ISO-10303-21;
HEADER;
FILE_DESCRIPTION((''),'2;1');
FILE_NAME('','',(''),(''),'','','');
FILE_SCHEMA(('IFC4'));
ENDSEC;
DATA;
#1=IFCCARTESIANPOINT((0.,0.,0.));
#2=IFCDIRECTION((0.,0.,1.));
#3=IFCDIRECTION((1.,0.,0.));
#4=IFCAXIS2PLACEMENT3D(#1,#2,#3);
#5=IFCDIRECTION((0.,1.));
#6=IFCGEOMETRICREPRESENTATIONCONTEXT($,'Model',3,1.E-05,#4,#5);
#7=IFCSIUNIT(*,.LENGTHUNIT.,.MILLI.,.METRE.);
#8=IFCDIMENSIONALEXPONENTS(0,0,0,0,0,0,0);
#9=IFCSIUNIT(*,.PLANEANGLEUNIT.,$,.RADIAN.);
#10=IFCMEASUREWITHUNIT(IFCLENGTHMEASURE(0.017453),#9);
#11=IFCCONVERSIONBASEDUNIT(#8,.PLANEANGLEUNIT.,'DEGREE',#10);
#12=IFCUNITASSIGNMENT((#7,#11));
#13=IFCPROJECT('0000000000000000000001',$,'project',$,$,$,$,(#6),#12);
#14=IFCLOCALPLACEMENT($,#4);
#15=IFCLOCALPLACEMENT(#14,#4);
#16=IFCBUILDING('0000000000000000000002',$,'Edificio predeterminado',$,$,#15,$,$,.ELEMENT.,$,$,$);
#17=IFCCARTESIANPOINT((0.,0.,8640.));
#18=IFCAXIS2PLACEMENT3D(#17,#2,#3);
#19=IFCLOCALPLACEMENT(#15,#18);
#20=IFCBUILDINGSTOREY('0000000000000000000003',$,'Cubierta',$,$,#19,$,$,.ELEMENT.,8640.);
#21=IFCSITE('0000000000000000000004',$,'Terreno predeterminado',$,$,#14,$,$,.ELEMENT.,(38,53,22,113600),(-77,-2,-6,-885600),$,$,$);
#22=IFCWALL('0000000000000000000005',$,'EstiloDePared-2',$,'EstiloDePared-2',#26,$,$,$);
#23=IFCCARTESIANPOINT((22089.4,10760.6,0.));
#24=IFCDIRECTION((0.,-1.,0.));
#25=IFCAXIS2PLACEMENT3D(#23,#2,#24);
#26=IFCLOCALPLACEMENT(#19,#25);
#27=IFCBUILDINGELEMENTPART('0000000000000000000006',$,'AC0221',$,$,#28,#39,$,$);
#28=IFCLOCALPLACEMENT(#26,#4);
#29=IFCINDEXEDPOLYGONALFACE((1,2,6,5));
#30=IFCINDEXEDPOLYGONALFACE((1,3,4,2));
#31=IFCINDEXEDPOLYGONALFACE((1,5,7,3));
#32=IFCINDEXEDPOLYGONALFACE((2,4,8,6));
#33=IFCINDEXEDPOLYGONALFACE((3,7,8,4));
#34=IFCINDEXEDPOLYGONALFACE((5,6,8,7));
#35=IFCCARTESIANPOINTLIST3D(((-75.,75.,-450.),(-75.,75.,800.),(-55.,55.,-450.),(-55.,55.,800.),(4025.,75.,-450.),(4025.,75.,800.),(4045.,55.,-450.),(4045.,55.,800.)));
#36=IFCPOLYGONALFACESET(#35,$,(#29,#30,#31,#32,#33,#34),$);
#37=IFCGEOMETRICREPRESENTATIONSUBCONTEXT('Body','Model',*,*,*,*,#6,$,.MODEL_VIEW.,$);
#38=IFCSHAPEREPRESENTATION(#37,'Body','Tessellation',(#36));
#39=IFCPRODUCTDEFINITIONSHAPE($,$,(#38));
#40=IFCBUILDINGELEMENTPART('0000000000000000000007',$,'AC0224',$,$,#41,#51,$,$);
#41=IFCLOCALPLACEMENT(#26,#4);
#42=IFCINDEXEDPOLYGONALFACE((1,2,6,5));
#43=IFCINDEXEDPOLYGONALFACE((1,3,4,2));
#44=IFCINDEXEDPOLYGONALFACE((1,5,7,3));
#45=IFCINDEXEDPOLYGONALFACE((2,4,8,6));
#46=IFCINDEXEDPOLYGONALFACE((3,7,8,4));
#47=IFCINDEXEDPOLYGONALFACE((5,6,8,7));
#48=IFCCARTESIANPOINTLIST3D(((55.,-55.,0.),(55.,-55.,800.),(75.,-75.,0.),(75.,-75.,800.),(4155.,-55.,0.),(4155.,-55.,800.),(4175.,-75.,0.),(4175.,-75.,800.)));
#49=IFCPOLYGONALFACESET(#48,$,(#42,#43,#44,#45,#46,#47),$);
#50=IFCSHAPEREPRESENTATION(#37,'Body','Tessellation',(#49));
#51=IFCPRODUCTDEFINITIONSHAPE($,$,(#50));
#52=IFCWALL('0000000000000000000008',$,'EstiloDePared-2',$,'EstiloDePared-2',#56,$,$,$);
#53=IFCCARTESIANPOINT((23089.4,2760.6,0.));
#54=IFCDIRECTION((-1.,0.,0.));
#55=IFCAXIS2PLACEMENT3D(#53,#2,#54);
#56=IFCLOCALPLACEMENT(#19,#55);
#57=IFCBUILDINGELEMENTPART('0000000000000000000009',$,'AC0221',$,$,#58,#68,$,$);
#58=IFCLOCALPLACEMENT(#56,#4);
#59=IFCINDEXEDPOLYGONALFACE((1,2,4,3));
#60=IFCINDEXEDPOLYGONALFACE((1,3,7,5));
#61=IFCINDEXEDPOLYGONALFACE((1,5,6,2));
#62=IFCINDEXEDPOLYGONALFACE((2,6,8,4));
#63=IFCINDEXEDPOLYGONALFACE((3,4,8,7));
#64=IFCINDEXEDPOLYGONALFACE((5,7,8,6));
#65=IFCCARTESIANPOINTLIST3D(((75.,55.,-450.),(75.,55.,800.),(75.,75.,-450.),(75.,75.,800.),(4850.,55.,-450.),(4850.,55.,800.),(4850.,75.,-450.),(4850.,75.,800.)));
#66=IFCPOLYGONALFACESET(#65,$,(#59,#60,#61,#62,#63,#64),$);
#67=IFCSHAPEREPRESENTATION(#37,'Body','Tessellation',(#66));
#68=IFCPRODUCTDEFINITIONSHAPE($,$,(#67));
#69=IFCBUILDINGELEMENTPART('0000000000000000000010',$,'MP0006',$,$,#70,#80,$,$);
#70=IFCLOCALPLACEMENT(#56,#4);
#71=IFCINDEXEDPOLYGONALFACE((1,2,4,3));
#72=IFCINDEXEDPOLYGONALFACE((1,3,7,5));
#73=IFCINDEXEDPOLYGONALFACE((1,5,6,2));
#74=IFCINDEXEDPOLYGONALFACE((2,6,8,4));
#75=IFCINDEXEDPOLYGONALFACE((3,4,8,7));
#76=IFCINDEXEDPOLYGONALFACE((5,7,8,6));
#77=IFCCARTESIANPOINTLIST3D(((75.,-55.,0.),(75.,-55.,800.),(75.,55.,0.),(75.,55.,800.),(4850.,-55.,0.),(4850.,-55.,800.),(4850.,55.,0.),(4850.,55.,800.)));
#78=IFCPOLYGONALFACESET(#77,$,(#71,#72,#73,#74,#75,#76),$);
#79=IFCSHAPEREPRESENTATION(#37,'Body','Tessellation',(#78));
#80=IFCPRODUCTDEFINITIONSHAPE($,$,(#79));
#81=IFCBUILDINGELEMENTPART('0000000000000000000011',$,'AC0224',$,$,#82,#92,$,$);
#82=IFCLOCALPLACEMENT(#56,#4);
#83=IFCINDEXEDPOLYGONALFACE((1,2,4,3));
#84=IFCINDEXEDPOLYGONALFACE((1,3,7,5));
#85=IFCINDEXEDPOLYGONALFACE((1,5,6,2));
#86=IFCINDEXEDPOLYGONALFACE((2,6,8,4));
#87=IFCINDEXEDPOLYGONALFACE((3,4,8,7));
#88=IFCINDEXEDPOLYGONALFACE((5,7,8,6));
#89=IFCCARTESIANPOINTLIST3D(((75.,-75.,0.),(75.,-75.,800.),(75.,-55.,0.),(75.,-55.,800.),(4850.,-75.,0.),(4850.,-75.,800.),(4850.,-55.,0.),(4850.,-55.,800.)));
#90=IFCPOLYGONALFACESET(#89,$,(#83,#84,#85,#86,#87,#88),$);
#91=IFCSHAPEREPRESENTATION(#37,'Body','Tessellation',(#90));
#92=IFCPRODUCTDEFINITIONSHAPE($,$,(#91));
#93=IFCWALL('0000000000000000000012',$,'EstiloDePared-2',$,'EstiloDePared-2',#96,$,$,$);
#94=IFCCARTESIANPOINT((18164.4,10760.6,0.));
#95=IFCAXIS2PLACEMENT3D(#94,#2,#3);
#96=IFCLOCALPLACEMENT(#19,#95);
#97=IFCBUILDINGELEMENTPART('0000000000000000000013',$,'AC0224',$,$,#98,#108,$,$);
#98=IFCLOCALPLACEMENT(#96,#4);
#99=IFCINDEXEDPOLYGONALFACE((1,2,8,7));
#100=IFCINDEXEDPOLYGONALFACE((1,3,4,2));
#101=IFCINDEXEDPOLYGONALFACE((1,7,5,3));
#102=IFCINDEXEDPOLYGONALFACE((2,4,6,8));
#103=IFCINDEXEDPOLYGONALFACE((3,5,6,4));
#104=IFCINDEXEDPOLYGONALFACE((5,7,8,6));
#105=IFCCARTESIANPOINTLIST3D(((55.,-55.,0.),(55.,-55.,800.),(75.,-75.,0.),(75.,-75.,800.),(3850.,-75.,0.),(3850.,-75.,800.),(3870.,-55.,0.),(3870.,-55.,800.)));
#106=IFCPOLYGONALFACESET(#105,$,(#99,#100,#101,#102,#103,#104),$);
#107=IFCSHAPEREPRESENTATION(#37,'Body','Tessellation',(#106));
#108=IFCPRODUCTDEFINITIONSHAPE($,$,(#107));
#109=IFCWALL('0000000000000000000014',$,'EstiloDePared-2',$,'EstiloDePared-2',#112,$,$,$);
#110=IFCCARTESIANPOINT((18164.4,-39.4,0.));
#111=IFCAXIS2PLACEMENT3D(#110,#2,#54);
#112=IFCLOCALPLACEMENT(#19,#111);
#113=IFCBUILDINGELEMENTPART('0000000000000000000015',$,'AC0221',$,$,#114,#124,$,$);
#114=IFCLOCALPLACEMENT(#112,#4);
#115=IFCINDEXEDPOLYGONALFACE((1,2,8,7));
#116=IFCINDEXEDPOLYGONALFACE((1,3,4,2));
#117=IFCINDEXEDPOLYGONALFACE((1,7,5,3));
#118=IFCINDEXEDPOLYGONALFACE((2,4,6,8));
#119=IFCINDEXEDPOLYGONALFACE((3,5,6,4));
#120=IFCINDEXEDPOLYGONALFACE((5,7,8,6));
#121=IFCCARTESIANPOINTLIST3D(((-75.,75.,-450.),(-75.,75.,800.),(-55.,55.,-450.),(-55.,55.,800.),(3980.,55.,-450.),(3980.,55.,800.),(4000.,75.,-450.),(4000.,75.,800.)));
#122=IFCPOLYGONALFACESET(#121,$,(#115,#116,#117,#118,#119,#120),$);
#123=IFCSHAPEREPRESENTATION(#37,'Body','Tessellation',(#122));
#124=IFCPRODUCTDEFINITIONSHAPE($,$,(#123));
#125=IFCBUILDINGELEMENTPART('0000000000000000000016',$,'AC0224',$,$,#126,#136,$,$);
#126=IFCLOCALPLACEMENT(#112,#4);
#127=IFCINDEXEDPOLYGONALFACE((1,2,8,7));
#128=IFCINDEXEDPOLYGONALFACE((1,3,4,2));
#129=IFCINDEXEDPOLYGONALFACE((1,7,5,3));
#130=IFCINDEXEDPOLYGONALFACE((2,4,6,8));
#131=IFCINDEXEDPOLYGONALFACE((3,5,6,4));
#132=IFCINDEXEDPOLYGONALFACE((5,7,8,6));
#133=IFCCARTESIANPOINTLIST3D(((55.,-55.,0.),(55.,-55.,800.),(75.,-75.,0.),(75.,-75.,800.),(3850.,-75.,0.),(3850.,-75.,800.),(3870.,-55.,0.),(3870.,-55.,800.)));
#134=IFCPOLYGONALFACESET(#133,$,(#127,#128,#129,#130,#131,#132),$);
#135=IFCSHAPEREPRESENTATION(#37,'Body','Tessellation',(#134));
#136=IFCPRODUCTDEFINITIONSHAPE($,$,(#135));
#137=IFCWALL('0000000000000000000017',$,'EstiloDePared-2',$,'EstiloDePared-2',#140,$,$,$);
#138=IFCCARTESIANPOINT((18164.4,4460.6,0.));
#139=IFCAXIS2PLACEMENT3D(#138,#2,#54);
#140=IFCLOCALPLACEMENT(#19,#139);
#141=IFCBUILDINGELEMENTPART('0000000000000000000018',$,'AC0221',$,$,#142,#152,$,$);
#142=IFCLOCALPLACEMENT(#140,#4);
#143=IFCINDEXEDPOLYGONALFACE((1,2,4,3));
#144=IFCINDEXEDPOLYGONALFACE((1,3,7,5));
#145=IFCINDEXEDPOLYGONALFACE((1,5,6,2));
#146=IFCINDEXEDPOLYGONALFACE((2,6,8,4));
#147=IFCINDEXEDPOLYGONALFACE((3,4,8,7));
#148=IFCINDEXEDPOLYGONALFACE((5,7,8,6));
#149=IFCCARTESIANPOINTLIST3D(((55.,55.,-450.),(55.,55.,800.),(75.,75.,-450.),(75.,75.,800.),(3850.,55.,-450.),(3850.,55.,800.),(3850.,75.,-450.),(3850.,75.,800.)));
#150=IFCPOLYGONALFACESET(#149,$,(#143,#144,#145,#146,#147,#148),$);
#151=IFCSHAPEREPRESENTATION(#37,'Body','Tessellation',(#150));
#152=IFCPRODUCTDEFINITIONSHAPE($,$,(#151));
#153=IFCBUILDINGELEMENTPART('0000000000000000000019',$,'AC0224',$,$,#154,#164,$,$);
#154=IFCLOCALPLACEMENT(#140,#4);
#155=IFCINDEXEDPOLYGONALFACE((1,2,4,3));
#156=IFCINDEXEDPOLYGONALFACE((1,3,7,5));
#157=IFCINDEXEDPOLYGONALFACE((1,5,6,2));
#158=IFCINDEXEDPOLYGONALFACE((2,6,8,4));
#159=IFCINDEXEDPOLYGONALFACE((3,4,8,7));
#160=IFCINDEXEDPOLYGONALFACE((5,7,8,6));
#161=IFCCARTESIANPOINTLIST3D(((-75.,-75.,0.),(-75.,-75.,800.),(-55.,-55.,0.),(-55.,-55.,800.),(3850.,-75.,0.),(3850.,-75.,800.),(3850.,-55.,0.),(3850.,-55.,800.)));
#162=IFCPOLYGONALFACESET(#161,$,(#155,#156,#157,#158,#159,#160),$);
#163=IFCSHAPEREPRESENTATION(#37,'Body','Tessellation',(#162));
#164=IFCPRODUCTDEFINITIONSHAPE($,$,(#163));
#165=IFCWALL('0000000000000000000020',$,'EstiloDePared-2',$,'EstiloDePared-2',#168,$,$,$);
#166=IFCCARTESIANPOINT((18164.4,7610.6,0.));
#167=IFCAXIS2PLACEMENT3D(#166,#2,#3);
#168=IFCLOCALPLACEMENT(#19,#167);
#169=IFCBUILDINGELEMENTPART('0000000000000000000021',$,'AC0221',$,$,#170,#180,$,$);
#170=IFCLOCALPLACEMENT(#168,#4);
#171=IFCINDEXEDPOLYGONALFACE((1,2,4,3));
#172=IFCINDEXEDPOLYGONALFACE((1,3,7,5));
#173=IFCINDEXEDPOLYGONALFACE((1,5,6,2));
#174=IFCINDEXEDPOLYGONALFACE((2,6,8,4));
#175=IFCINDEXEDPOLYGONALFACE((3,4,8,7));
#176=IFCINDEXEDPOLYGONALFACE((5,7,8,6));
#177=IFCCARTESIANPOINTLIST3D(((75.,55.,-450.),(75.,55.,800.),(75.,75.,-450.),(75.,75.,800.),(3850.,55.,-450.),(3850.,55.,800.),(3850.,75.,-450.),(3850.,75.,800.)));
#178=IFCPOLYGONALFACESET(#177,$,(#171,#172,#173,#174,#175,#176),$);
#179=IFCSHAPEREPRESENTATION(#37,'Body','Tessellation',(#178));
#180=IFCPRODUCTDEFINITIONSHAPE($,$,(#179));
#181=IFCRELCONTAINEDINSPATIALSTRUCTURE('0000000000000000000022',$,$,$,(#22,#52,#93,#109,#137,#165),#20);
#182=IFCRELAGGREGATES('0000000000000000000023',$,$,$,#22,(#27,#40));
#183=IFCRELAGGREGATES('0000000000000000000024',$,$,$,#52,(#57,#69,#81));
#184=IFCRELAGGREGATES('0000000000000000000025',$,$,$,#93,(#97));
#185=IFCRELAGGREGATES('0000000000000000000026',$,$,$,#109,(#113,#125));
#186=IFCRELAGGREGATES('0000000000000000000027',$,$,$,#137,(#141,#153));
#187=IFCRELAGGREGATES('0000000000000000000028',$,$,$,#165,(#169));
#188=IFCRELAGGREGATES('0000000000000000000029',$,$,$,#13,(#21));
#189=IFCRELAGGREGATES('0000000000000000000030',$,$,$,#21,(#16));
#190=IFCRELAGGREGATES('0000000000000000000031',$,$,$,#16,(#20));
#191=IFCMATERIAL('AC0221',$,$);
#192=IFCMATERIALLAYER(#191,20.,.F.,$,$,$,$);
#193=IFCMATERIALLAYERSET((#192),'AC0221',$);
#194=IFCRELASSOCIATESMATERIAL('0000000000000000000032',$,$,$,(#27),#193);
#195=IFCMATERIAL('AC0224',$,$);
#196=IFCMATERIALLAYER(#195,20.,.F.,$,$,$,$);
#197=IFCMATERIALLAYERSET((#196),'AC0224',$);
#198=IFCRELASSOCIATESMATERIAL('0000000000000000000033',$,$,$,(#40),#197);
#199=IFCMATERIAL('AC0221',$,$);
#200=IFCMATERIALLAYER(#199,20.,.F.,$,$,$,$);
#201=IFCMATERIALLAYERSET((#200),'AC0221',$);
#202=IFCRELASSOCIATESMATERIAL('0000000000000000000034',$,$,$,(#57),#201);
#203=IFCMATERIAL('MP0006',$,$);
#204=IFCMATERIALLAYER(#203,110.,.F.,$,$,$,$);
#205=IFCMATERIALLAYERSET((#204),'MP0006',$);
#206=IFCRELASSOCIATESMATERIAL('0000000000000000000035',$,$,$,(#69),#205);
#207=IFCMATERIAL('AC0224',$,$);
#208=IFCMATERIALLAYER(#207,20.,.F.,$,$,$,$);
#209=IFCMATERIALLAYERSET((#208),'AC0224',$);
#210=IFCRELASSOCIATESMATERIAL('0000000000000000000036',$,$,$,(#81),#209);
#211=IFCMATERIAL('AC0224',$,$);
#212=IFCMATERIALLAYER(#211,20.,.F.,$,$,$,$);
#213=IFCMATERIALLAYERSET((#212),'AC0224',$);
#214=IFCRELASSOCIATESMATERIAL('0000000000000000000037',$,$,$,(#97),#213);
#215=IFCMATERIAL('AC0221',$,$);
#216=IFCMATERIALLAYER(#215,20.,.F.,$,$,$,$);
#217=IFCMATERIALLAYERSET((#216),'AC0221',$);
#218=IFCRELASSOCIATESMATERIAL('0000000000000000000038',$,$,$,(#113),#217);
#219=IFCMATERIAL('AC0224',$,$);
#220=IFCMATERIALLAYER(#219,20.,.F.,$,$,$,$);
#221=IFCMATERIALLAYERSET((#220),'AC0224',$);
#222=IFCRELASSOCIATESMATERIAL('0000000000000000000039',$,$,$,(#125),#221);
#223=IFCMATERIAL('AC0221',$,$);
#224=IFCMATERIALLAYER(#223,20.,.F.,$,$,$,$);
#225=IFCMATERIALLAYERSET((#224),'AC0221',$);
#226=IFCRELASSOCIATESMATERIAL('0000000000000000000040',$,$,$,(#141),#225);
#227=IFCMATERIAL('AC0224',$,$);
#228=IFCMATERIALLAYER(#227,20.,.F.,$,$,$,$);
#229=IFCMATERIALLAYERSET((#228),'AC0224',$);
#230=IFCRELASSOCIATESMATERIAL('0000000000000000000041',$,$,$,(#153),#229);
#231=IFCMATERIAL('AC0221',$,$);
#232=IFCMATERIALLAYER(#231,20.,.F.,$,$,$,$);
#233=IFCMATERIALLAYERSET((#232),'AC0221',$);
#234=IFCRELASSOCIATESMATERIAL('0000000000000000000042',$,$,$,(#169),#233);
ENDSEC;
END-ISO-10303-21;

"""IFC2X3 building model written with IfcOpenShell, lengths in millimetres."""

from ifc_helpers import new_model, entity, si_unit, converted_unit, direction, frame, origin_with_axes, place, context, subcontext, project, spatial, polyline, outline, extrude, material, layer, layer_set, layer_usage, element, aggregate, save


model = new_model("IFC2X3")

# Units and contexts
model_context = context("Model", 3, precision=1e-05, world=origin_with_axes(), true_north=direction((0.0, 1.0)))
body_context = subcontext(model_context, "Body", "Model", "MODEL_VIEW")
ifc_project = project(units=[si_unit("LENGTHUNIT", "METRE", prefix="MILLI"), converted_unit("PLANEANGLEUNIT", "DEGREE", entity("IfcLengthMeasure", 0.017453), si_unit("PLANEANGLEUNIT", "RADIAN"), dimensions=[0, 0, 0, 0, 0, 0, 0])], contexts=[model_context])

# Site, building, storey
site_placement = place(None, origin_with_axes())
site = spatial("IfcSite", under=ifc_project, at=site_placement, Name="Terreno predeterminado", CompositionType="ELEMENT", RefLatitude=(38, 53, 22, 113600), RefLongitude=(-77, -2, -6, -885600))
building_placement = place(site_placement, origin_with_axes())
building = spatial("IfcBuilding", under=site, at=building_placement, Name="Edificio predeterminado", CompositionType="ELEMENT")
storey_placement = place(building_placement, frame((0.0, 0.0, 8640.0), z_axis=(0.0, 0.0, 1.0), x_axis=(1.0, 0.0, 0.0)))
storey = spatial("IfcBuildingStorey", under=building, at=storey_placement, Name="Cubierta", CompositionType="ELEMENT", Elevation=8640.0)

# Walls, building element parts
wall_1_placement = place(storey_placement, frame((22089.4, 10760.6, 0.0), z_axis=(0.0, 0.0, 1.0), x_axis=(0.0, -1.0, 0.0)))
wall_1 = element("IfcWall", 1, at=wall_1_placement, inside=storey, Name="EstiloDePared-2", ObjectType="EstiloDePared-2")
ifc_material_1 = material(Name="AC0221")
ifc_layer_1 = layer(ifc_material_1, 20.0, ventilated=False)
ifc_layer_set_1 = layer_set([ifc_layer_1], Name="AC0221")
ifc_layer_usage_1 = layer_usage(ifc_layer_set_1, "AXIS2", "NEGATIVE", -75.0)
building_element_part_1_placement = place(wall_1_placement, origin_with_axes())
building_element_part_1 = element("IfcBuildingElementPart", 2, at=building_element_part_1_placement, material=ifc_layer_usage_1, Name="AC0221", context=body_context, shape_type="SweptSolid", body=[
    extrude(outline(polyline([(4025.0, 75.0), (4045.0, 55.0), (-55.0, 55.0), (-75.0, 75.0), (4025.0, 75.0)])), frame((0.0, 0.0, -450.0), z_axis=(0.0, 0.0, 1.0), x_axis=(1.0, 0.0, 0.0)), (0.0, 0.0, 1.0), 1250.0),
])
ifc_material_2 = material(Name="AC0224")
ifc_layer_2 = layer(ifc_material_2, 20.0, ventilated=False)
ifc_layer_set_2 = layer_set([ifc_layer_2], Name="AC0224")
ifc_layer_usage_2 = layer_usage(ifc_layer_set_2, "AXIS2", "NEGATIVE", 55.0)
building_element_part_2_placement = place(wall_1_placement, origin_with_axes())
building_element_part_2 = element("IfcBuildingElementPart", 3, at=building_element_part_2_placement, material=ifc_layer_usage_2, Name="AC0224", context=body_context, shape_type="SweptSolid", body=[
    extrude(outline(polyline([(4155.0, -55.0), (4175.0, -75.0), (75.0, -75.0), (55.0, -55.0), (4155.0, -55.0)])), origin_with_axes(), (0.0, 0.0, 1.0), 800.0),
])
aggregate(wall_1, [building_element_part_1, building_element_part_2])
wall_2_placement = place(storey_placement, frame((23089.4, 2760.6, 0.0), z_axis=(0.0, 0.0, 1.0), x_axis=(-1.0, 0.0, 0.0)))
wall_2 = element("IfcWall", 4, at=wall_2_placement, inside=storey, Name="EstiloDePared-2", ObjectType="EstiloDePared-2")
ifc_material_3 = material(Name="AC0221")
ifc_layer_3 = layer(ifc_material_3, 20.0, ventilated=False)
ifc_layer_set_3 = layer_set([ifc_layer_3], Name="AC0221")
ifc_layer_usage_3 = layer_usage(ifc_layer_set_3, "AXIS2", "NEGATIVE", -75.0)
building_element_part_3_placement = place(wall_2_placement, origin_with_axes())
building_element_part_3 = element("IfcBuildingElementPart", 5, at=building_element_part_3_placement, material=ifc_layer_usage_3, Name="AC0221", context=body_context, shape_type="SweptSolid", body=[
    extrude(outline(polyline([(4850.0, 75.0), (4850.0, 55.0), (75.0, 55.0), (75.0, 75.0), (4850.0, 75.0)])), frame((0.0, 0.0, -450.0), z_axis=(0.0, 0.0, 1.0), x_axis=(1.0, 0.0, 0.0)), (0.0, 0.0, 1.0), 1250.0),
])
ifc_material_4 = material(Name="MP0006")
ifc_layer_4 = layer(ifc_material_4, 110.0, ventilated=False)
ifc_layer_set_4 = layer_set([ifc_layer_4], Name="MP0006")
ifc_layer_usage_4 = layer_usage(ifc_layer_set_4, "AXIS2", "NEGATIVE", -55.0)
building_element_part_4_placement = place(wall_2_placement, origin_with_axes())
building_element_part_4 = element("IfcBuildingElementPart", 6, at=building_element_part_4_placement, material=ifc_layer_usage_4, Name="MP0006", context=body_context, shape_type="SweptSolid", body=[
    extrude(outline(polyline([(4850.0, 55.0), (4850.0, -55.0), (75.0, -55.0), (75.0, 55.0), (4850.0, 55.0)])), origin_with_axes(), (0.0, 0.0, 1.0), 800.0),
])
ifc_material_5 = material(Name="AC0224")
ifc_layer_5 = layer(ifc_material_5, 20.0, ventilated=False)
ifc_layer_set_5 = layer_set([ifc_layer_5], Name="AC0224")
ifc_layer_usage_5 = layer_usage(ifc_layer_set_5, "AXIS2", "NEGATIVE", 55.0)
building_element_part_5_placement = place(wall_2_placement, origin_with_axes())
building_element_part_5 = element("IfcBuildingElementPart", 7, at=building_element_part_5_placement, material=ifc_layer_usage_5, Name="AC0224", context=body_context, shape_type="SweptSolid", body=[
    extrude(outline(polyline([(4850.0, -55.0), (4850.0, -75.0), (75.0, -75.0), (75.0, -55.0), (4850.0, -55.0)])), origin_with_axes(), (0.0, 0.0, 1.0), 800.0),
])
aggregate(wall_2, [building_element_part_3, building_element_part_4, building_element_part_5])

# Wall, building element part
wall_3_placement = place(storey_placement, frame((18164.4, 10760.6, 0.0), z_axis=(0.0, 0.0, 1.0), x_axis=(1.0, 0.0, 0.0)))
wall_3 = element("IfcWall", 8, at=wall_3_placement, inside=storey, Name="EstiloDePared-2", ObjectType="EstiloDePared-2")
ifc_material_6 = material(Name="AC0224")
ifc_layer_6 = layer(ifc_material_6, 20.0, ventilated=False)
ifc_layer_set_6 = layer_set([ifc_layer_6], Name="AC0224")
ifc_layer_usage_6 = layer_usage(ifc_layer_set_6, "AXIS2", "NEGATIVE", 55.0)
building_element_part_6_placement = place(wall_3_placement, origin_with_axes())
building_element_part_6 = element("IfcBuildingElementPart", 9, at=building_element_part_6_placement, material=ifc_layer_usage_6, Name="AC0224", context=body_context, shape_type="SweptSolid", body=[
    extrude(outline(polyline([(3870.0, -55.0), (3850.0, -75.0), (75.0, -75.0), (55.0, -55.0), (3870.0, -55.0)])), origin_with_axes(), (0.0, 0.0, 1.0), 800.0),
])
aggregate(wall_3, [building_element_part_6])

# Walls, building element parts
wall_4_placement = place(storey_placement, frame((18164.4, -39.4, 0.0), z_axis=(0.0, 0.0, 1.0), x_axis=(-1.0, 0.0, 0.0)))
wall_4 = element("IfcWall", 10, at=wall_4_placement, inside=storey, Name="EstiloDePared-2", ObjectType="EstiloDePared-2")
ifc_material_7 = material(Name="AC0221")
ifc_layer_7 = layer(ifc_material_7, 20.0, ventilated=False)
ifc_layer_set_7 = layer_set([ifc_layer_7], Name="AC0221")
ifc_layer_usage_7 = layer_usage(ifc_layer_set_7, "AXIS2", "NEGATIVE", -75.0)
building_element_part_7_placement = place(wall_4_placement, origin_with_axes())
building_element_part_7 = element("IfcBuildingElementPart", 11, at=building_element_part_7_placement, material=ifc_layer_usage_7, Name="AC0221", context=body_context, shape_type="SweptSolid", body=[
    extrude(outline(polyline([(4000.0, 75.0), (3980.0, 55.0), (-55.0, 55.0), (-75.0, 75.0), (4000.0, 75.0)])), frame((0.0, 0.0, -450.0), z_axis=(0.0, 0.0, 1.0), x_axis=(1.0, 0.0, 0.0)), (0.0, 0.0, 1.0), 1250.0),
])
ifc_material_8 = material(Name="AC0224")
ifc_layer_8 = layer(ifc_material_8, 20.0, ventilated=False)
ifc_layer_set_8 = layer_set([ifc_layer_8], Name="AC0224")
ifc_layer_usage_8 = layer_usage(ifc_layer_set_8, "AXIS2", "NEGATIVE", 55.0)
building_element_part_8_placement = place(wall_4_placement, origin_with_axes())
building_element_part_8 = element("IfcBuildingElementPart", 12, at=building_element_part_8_placement, material=ifc_layer_usage_8, Name="AC0224", context=body_context, shape_type="SweptSolid", body=[
    extrude(outline(polyline([(3870.0, -55.0), (3850.0, -75.0), (75.0, -75.0), (55.0, -55.0), (3870.0, -55.0)])), origin_with_axes(), (0.0, 0.0, 1.0), 800.0),
])
aggregate(wall_4, [building_element_part_7, building_element_part_8])
wall_5_placement = place(storey_placement, frame((18164.4, 4460.6, 0.0), z_axis=(0.0, 0.0, 1.0), x_axis=(-1.0, 0.0, 0.0)))
wall_5 = element("IfcWall", 13, at=wall_5_placement, inside=storey, Name="EstiloDePared-2", ObjectType="EstiloDePared-2")
ifc_material_9 = material(Name="AC0221")
ifc_layer_9 = layer(ifc_material_9, 20.0, ventilated=False)
ifc_layer_set_9 = layer_set([ifc_layer_9], Name="AC0221")
ifc_layer_usage_9 = layer_usage(ifc_layer_set_9, "AXIS2", "NEGATIVE", -75.0)
building_element_part_9_placement = place(wall_5_placement, origin_with_axes())
building_element_part_9 = element("IfcBuildingElementPart", 14, at=building_element_part_9_placement, material=ifc_layer_usage_9, Name="AC0221", context=body_context, shape_type="SweptSolid", body=[
    extrude(outline(polyline([(3850.0, 75.0), (3850.0, 55.0), (55.0, 55.0), (75.0, 75.0), (3850.0, 75.0)])), frame((0.0, 0.0, -450.0), z_axis=(0.0, 0.0, 1.0), x_axis=(1.0, 0.0, 0.0)), (0.0, 0.0, 1.0), 1250.0),
])
ifc_material_10 = material(Name="AC0224")
ifc_layer_10 = layer(ifc_material_10, 20.0, ventilated=False)
ifc_layer_set_10 = layer_set([ifc_layer_10], Name="AC0224")
ifc_layer_usage_10 = layer_usage(ifc_layer_set_10, "AXIS2", "NEGATIVE", 55.0)
building_element_part_10_placement = place(wall_5_placement, origin_with_axes())
building_element_part_10 = element("IfcBuildingElementPart", 15, at=building_element_part_10_placement, material=ifc_layer_usage_10, Name="AC0224", context=body_context, shape_type="SweptSolid", body=[
    extrude(outline(polyline([(3850.0, -55.0), (3850.0, -75.0), (-75.0, -75.0), (-55.0, -55.0), (3850.0, -55.0)])), origin_with_axes(), (0.0, 0.0, 1.0), 800.0),
])
aggregate(wall_5, [building_element_part_9, building_element_part_10])
wall_6_placement = place(storey_placement, frame((18164.4, 7610.6, 0.0), z_axis=(0.0, 0.0, 1.0), x_axis=(1.0, 0.0, 0.0)))
wall_6 = element("IfcWall", 16, at=wall_6_placement, inside=storey, Name="EstiloDePared-2", ObjectType="EstiloDePared-2")
ifc_material_11 = material(Name="AC0221")
ifc_layer_11 = layer(ifc_material_11, 20.0, ventilated=False)
ifc_layer_set_11 = layer_set([ifc_layer_11], Name="AC0221")
ifc_layer_usage_11 = layer_usage(ifc_layer_set_11, "AXIS2", "NEGATIVE", -75.0)
building_element_part_11_placement = place(wall_6_placement, origin_with_axes())
building_element_part_11 = element("IfcBuildingElementPart", 17, at=building_element_part_11_placement, material=ifc_layer_usage_11, Name="AC0221", context=body_context, shape_type="SweptSolid", body=[
    extrude(outline(polyline([(3850.0, 75.0), (3850.0, 55.0), (75.0, 55.0), (75.0, 75.0), (3850.0, 75.0)])), frame((0.0, 0.0, -450.0), z_axis=(0.0, 0.0, 1.0), x_axis=(1.0, 0.0, 0.0)), (0.0, 0.0, 1.0), 1250.0),
])
aggregate(wall_6, [building_element_part_11])

save(model, "model.ifc")
